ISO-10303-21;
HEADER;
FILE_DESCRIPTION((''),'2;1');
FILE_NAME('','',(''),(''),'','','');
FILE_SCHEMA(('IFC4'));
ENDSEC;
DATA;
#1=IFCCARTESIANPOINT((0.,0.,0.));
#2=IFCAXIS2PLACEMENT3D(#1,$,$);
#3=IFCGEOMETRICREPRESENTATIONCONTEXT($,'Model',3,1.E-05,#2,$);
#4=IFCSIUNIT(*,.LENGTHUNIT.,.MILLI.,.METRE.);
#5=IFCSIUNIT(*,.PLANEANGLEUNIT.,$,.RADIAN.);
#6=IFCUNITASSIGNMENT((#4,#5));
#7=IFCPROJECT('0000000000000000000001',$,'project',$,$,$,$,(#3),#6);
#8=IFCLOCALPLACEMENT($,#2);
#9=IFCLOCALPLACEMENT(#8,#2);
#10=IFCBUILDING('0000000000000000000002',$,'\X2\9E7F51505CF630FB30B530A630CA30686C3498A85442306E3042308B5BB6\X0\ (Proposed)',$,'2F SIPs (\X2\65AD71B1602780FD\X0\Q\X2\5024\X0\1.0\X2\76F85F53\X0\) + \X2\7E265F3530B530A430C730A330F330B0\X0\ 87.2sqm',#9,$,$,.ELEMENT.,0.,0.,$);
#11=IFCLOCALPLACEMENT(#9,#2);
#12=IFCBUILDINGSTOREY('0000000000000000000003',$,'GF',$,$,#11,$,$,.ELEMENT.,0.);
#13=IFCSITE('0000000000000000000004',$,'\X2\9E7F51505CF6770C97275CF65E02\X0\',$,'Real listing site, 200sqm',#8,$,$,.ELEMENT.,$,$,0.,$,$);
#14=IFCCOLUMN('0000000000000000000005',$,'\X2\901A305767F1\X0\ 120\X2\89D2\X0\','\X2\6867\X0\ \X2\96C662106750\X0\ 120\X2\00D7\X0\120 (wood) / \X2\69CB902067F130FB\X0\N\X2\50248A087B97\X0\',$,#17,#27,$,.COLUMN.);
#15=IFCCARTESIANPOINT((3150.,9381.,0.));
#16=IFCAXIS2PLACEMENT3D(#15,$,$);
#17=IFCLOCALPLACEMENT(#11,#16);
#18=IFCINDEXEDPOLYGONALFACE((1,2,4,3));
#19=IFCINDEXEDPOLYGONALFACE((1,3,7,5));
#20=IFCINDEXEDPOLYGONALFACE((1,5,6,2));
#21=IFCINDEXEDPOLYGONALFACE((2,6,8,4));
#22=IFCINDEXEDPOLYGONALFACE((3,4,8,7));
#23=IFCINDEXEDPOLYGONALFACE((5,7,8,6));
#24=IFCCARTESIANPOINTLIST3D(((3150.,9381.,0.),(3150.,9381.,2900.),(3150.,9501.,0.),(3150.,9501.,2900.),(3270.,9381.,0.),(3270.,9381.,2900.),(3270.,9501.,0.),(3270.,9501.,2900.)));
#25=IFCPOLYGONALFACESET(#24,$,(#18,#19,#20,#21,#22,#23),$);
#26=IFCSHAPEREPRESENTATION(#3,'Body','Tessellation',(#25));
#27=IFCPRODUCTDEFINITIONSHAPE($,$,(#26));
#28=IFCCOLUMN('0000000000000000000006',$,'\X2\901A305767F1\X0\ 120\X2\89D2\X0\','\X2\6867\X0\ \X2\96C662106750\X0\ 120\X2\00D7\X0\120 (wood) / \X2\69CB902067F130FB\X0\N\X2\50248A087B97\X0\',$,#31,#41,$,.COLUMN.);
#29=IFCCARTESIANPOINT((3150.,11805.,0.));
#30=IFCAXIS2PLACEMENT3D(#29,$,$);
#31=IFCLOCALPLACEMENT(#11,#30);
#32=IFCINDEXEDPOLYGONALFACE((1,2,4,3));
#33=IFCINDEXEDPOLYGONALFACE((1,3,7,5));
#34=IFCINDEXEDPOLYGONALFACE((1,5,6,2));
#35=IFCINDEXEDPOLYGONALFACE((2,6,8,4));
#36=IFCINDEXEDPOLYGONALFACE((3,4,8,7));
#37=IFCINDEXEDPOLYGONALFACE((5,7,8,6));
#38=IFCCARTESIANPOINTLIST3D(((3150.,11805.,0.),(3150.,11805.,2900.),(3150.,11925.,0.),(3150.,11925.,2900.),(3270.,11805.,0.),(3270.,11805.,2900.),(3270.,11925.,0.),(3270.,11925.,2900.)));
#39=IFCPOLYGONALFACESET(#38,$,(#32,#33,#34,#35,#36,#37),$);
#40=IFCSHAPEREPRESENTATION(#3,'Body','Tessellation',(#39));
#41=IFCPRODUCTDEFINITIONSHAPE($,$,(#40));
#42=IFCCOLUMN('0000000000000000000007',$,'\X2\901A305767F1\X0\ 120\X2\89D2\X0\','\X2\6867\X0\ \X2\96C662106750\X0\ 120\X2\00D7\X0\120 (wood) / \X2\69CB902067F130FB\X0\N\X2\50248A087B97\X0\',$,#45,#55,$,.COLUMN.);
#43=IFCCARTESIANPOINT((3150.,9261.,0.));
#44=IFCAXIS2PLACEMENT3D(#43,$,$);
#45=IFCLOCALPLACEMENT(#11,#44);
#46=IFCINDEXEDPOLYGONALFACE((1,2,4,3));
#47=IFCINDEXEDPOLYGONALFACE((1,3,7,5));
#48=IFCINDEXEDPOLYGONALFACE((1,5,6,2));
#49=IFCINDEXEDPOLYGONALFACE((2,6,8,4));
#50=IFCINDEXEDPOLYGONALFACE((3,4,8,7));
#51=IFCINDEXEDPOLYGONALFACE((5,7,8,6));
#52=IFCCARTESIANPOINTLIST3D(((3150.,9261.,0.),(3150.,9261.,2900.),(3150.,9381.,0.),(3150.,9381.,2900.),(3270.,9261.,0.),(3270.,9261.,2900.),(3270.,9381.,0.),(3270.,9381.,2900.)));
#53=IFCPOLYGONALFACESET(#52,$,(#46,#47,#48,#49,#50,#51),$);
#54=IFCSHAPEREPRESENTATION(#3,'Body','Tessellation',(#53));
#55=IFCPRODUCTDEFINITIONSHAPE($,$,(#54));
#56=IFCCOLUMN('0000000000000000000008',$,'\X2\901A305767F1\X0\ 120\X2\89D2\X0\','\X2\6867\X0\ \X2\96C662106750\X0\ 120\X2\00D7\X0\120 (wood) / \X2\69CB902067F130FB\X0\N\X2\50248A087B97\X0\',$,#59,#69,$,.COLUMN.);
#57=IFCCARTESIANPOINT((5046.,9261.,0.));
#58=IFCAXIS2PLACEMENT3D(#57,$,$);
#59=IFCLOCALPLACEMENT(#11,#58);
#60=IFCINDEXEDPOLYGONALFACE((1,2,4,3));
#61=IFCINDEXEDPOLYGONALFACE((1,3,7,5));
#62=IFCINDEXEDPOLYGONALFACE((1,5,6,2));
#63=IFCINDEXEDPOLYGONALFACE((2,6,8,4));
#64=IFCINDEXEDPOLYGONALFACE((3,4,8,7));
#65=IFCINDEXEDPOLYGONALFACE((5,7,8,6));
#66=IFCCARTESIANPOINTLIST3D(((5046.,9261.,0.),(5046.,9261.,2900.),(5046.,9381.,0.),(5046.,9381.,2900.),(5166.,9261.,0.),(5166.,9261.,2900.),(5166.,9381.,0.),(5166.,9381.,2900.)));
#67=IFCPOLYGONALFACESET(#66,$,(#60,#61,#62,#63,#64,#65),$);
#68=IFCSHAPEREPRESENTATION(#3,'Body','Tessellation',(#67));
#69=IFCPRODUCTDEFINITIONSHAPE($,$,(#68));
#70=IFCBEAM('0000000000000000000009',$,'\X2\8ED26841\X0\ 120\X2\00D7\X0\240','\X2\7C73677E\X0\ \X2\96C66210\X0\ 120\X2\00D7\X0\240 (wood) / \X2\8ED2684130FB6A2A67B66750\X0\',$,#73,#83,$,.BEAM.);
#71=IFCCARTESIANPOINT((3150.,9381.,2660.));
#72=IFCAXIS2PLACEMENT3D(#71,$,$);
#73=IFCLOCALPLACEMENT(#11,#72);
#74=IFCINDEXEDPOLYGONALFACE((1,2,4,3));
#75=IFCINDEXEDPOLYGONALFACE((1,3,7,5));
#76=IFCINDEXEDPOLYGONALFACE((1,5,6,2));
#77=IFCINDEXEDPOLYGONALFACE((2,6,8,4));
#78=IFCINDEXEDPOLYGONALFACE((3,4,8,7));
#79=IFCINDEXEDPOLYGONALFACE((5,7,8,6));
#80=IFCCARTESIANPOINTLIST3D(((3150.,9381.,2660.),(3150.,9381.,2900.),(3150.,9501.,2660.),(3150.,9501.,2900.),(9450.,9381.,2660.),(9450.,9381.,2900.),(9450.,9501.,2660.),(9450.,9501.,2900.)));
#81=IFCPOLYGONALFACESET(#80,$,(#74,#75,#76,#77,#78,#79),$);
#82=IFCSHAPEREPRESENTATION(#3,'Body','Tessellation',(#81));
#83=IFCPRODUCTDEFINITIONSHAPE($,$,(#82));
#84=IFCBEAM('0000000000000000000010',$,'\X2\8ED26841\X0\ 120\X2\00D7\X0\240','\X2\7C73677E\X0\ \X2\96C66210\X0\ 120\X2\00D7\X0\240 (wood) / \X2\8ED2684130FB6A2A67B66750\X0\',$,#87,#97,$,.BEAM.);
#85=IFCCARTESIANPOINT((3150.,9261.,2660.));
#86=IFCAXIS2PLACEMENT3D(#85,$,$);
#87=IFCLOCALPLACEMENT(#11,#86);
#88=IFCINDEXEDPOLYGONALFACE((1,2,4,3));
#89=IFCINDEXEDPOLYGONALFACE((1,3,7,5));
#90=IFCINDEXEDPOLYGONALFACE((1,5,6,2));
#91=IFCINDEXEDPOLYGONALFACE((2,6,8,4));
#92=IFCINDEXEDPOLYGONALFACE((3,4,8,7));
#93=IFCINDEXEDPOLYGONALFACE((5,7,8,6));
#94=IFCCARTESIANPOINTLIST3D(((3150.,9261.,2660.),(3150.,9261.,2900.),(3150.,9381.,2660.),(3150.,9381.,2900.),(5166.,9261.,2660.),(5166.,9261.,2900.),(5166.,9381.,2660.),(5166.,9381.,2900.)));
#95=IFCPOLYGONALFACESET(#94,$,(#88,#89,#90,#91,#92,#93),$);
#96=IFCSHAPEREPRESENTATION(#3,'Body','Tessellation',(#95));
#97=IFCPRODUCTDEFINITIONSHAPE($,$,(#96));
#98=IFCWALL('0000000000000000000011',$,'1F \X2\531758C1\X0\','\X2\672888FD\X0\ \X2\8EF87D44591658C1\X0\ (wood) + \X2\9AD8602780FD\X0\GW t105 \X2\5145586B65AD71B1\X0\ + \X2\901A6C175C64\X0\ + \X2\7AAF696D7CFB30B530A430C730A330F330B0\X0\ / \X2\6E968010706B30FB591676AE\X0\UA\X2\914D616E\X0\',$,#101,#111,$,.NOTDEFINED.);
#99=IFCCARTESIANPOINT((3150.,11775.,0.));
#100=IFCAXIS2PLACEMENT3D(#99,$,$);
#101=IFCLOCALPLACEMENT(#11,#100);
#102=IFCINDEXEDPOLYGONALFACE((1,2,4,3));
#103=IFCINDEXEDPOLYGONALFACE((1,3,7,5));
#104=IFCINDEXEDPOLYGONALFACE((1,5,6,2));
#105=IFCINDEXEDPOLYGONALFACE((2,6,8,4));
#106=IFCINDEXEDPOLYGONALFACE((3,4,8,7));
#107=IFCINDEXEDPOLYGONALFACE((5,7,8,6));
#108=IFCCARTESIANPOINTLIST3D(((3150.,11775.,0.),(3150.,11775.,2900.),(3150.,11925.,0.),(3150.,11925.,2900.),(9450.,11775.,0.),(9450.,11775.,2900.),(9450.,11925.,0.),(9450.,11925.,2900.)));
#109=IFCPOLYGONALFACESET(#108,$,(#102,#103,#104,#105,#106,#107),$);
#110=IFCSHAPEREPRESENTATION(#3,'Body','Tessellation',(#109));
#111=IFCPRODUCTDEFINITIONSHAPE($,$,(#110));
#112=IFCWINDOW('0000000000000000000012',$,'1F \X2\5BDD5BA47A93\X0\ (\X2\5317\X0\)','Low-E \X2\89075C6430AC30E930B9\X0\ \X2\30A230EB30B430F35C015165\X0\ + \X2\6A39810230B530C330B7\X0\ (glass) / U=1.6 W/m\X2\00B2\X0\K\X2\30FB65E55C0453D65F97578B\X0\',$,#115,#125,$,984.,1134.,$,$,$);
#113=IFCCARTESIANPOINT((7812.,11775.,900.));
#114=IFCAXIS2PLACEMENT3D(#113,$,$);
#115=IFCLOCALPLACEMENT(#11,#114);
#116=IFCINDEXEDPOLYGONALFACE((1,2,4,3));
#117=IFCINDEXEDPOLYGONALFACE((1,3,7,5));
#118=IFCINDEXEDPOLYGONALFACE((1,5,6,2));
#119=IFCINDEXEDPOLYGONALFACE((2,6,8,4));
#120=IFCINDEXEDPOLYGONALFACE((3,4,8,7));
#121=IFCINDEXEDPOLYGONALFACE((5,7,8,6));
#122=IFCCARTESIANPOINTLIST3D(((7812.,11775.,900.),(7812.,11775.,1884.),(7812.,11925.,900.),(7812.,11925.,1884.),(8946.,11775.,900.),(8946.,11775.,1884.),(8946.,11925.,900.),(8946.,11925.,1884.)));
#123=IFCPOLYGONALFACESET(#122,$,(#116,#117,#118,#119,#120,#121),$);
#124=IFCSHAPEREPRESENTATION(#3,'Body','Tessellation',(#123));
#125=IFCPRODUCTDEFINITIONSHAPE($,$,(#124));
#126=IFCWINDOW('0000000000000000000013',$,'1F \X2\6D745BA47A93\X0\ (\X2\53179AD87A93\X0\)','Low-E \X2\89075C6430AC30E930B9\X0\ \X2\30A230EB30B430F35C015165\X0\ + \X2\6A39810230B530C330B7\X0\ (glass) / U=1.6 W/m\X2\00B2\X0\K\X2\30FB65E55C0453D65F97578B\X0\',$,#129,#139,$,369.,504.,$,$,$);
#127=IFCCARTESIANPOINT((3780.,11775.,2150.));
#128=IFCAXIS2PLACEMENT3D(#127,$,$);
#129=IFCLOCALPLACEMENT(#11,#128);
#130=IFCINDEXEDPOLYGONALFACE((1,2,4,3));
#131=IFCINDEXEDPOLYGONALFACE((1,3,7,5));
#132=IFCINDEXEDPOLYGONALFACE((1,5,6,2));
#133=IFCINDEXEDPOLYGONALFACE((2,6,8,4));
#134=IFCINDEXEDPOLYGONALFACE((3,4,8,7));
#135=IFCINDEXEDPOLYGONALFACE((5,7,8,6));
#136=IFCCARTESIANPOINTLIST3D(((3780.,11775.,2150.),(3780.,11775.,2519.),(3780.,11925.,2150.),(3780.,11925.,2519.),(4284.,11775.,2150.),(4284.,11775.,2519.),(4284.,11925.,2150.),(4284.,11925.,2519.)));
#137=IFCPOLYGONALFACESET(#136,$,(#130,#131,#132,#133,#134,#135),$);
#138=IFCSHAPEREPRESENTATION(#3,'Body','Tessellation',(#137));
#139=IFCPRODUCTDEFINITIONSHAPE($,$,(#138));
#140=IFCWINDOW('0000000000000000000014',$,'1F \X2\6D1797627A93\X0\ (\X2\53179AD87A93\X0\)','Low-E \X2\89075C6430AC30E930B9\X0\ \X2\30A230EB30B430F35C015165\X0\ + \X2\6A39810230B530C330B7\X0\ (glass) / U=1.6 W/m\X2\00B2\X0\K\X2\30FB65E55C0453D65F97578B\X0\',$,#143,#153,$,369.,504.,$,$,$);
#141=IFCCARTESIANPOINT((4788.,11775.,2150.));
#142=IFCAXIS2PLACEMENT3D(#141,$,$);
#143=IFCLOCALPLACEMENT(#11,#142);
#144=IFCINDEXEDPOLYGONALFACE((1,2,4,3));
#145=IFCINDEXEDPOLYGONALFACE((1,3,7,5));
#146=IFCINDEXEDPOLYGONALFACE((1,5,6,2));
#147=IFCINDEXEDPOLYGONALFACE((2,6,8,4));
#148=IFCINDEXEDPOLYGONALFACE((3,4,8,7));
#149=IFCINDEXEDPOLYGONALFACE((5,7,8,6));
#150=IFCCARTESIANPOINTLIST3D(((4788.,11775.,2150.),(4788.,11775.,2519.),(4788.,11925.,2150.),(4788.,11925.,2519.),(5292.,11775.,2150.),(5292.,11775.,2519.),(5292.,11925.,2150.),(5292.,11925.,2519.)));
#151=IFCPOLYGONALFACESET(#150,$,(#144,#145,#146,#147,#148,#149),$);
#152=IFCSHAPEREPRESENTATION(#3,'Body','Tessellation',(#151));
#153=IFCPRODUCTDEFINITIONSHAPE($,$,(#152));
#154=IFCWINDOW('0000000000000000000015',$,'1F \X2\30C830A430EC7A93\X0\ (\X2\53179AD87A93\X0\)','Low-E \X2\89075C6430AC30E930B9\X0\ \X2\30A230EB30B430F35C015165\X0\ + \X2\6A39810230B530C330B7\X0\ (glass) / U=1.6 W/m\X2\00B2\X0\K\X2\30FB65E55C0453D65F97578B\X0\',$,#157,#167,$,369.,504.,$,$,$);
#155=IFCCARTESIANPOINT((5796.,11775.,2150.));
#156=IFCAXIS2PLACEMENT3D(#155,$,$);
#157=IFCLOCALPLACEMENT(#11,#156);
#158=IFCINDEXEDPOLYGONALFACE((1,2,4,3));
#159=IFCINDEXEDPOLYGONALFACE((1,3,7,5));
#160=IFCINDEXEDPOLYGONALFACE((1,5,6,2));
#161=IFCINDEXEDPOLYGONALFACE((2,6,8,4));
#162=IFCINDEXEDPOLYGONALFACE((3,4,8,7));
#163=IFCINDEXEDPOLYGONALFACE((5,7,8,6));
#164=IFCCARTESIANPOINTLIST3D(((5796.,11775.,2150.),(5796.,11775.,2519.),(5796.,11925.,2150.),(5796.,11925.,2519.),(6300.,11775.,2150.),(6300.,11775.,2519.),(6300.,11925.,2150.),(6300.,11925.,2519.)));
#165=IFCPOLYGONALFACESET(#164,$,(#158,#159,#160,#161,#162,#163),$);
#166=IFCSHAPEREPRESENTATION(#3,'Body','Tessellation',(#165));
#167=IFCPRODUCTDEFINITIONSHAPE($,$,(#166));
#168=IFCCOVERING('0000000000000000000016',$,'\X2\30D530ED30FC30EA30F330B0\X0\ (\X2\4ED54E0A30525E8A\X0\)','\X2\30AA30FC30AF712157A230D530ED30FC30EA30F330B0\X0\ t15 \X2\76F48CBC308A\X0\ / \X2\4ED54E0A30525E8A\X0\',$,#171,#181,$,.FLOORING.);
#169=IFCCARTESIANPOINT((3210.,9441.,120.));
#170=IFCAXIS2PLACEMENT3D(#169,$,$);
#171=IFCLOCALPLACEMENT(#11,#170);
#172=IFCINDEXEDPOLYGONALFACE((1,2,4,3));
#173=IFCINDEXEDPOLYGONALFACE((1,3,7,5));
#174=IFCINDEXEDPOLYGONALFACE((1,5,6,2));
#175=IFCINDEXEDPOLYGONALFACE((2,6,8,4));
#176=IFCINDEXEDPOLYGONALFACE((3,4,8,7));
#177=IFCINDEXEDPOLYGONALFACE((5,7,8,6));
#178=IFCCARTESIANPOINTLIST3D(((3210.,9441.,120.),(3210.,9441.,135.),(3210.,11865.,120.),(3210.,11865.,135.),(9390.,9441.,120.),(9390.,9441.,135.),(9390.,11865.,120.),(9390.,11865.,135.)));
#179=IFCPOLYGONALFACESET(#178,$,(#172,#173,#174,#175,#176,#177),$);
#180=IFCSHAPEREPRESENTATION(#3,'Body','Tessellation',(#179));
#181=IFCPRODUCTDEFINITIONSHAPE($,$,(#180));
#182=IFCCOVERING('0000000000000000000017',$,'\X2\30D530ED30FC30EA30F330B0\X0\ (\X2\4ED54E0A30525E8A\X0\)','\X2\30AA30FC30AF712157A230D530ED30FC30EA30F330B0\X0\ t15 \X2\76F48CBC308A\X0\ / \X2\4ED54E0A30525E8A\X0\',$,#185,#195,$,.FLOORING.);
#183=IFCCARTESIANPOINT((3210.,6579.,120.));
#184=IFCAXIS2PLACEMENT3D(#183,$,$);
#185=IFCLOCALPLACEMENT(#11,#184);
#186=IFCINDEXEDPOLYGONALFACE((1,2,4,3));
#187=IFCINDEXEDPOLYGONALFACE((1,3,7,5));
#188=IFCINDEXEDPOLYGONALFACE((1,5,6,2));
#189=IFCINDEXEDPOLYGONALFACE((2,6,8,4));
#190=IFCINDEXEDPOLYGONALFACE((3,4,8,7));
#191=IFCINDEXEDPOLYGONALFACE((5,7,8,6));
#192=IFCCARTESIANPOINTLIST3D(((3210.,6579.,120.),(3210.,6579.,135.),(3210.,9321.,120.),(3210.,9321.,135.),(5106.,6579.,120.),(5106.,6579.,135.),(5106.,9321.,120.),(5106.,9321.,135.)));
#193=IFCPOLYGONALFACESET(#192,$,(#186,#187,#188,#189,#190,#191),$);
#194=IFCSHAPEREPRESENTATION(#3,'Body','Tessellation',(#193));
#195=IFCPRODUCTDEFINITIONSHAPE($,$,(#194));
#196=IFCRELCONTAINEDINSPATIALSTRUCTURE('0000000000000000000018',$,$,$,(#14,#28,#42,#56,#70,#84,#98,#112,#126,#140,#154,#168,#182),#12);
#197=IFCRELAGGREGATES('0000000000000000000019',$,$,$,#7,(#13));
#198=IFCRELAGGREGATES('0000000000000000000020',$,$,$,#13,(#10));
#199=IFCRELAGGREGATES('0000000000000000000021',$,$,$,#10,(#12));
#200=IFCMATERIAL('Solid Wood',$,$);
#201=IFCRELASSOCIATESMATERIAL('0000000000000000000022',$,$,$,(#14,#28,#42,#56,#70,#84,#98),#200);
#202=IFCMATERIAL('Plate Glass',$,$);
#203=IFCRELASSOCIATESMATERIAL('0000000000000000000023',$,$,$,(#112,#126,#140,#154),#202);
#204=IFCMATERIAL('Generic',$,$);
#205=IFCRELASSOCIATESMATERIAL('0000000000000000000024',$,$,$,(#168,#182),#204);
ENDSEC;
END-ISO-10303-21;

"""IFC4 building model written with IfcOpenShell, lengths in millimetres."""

from ifc_helpers import new_model, si_unit, frame, frame_2d, origin, place, context, project, spatial, rectangle, extrude, material, element, fill, save


model = new_model("IFC4")

# Units and contexts
model_context = context("Model", 3, precision=1e-05, world=origin())
ifc_project = project(units=[si_unit("LENGTHUNIT", "METRE", prefix="MILLI"), si_unit("PLANEANGLEUNIT", "RADIAN")], contexts=[model_context])

# Site, building, storey
site_placement = place(None, origin())
site = spatial("IfcSite", under=ifc_project, at=site_placement, Name="鹿児島県霧島市", ObjectType="Real listing site, 200sqm", CompositionType="ELEMENT", RefElevation=0.0)
building_placement = place(site_placement, origin())
building = spatial("IfcBuilding", under=site, at=building_placement, Name="鹿児島・サウナと水風呂のある家 (Proposed)", ObjectType="2F SIPs (断熱性能Q値1.0相当) + 縦張サイディング 87.2sqm", CompositionType="ELEMENT", ElevationOfRefHeight=0.0, ElevationOfTerrain=0.0)
storey_placement = place(building_placement, origin())
storey = spatial("IfcBuildingStorey", under=building, at=storey_placement, Name="GF", CompositionType="ELEMENT", Elevation=0.0)

# Columns
ifc_material_1 = material(Name="Solid Wood")
column_1_placement = place(storey_placement, frame((3150.0, 9381.0, 0.0)))
element("IfcColumn", 1, at=column_1_placement, inside=storey, material=ifc_material_1, Name="通し柱 120角", Description="桧 集成材 120×120 (wood) / 構造柱・N値計算", PredefinedType="COLUMN", context=model_context, shape_type="SweptSolid", body=[
    extrude(rectangle(XDim=120.0, YDim=120.0, at=frame_2d((60.0, 60.0))), frame((3150.0, 9381.0, 0.0)), (0.0, 0.0, 1.0), 2900.0),
])
column_2_placement = place(storey_placement, frame((3150.0, 11805.0, 0.0)))
element("IfcColumn", 2, at=column_2_placement, inside=storey, material=ifc_material_1, Name="通し柱 120角", Description="桧 集成材 120×120 (wood) / 構造柱・N値計算", PredefinedType="COLUMN", context=model_context, shape_type="SweptSolid", body=[
    extrude(rectangle(XDim=120.0, YDim=120.0, at=frame_2d((60.0, 60.0))), frame((3150.0, 11805.0, 0.0)), (0.0, 0.0, 1.0), 2900.0),
])
column_3_placement = place(storey_placement, frame((3150.0, 9261.0, 0.0)))
element("IfcColumn", 3, at=column_3_placement, inside=storey, material=ifc_material_1, Name="通し柱 120角", Description="桧 集成材 120×120 (wood) / 構造柱・N値計算", PredefinedType="COLUMN", context=model_context, shape_type="SweptSolid", body=[
    extrude(rectangle(XDim=120.0, YDim=120.0, at=frame_2d((60.0, 60.0))), frame((3150.0, 9261.0, 0.0)), (0.0, 0.0, 1.0), 2900.0),
])
column_4_placement = place(storey_placement, frame((5046.0, 9261.0, 0.0)))
element("IfcColumn", 4, at=column_4_placement, inside=storey, material=ifc_material_1, Name="通し柱 120角", Description="桧 集成材 120×120 (wood) / 構造柱・N値計算", PredefinedType="COLUMN", context=model_context, shape_type="SweptSolid", body=[
    extrude(rectangle(XDim=120.0, YDim=120.0, at=frame_2d((60.0, 60.0))), frame((5046.0, 9261.0, 0.0)), (0.0, 0.0, 1.0), 2900.0),
])

# Beams
beam_1_placement = place(storey_placement, frame((3150.0, 9381.0, 2660.0)))
element("IfcBeam", 5, at=beam_1_placement, inside=storey, material=ifc_material_1, Name="軒桁 120×240", Description="米松 集成 120×240 (wood) / 軒桁・横架材", PredefinedType="BEAM", context=model_context, shape_type="SweptSolid", body=[
    extrude(rectangle(XDim=6300.0, YDim=120.0, at=frame_2d((3150.0, 60.0))), frame((3150.0, 9381.0, 2660.0)), (0.0, 0.0, 1.0), 240.0),
])
beam_2_placement = place(storey_placement, frame((3150.0, 9261.0, 2660.0)))
element("IfcBeam", 6, at=beam_2_placement, inside=storey, material=ifc_material_1, Name="軒桁 120×240", Description="米松 集成 120×240 (wood) / 軒桁・横架材", PredefinedType="BEAM", context=model_context, shape_type="SweptSolid", body=[
    extrude(rectangle(XDim=2016.0, YDim=120.0, at=frame_2d((1008.0, 60.0))), frame((3150.0, 9261.0, 2660.0)), (0.0, 0.0, 1.0), 240.0),
])

# Wall, openings, windows
wall_1_placement = place(storey_placement, frame((3150.0, 11775.0, 0.0)))
wall_1 = element("IfcWall", 7, at=wall_1_placement, inside=storey, material=ifc_material_1, Name="1F 北壁", Description="木製 軸組外壁 (wood) + 高性能GW t105 充填断熱 + 通気層 + 窯業系サイディング / 準耐火・外皮UA配慮", PredefinedType="NOTDEFINED", context=model_context, shape_type="SweptSolid", body=[
    extrude(rectangle(XDim=6300.0, YDim=150.0, at=frame_2d((3150.0, 75.0))), frame((3150.0, 11775.0, 0.0)), (0.0, 0.0, 1.0), 2900.0),
])
opening_1_placement = place(storey_placement, frame((7812.0, 11775.0, 900.0)))
opening_1 = element("IfcOpeningElement", 8, at=opening_1_placement, cuts=wall_1, PredefinedType="NOTDEFINED", context=model_context, shape_type="SweptSolid", body=[
    extrude(rectangle(XDim=1134.0, YDim=150.0, at=frame_2d((567.0, 75.0))), frame((7812.0, 11775.0, 900.0)), (0.0, 0.0, 1.0), 984.0),
])
opening_2_placement = place(storey_placement, frame((3780.0, 11775.0, 2150.0)))
opening_2 = element("IfcOpeningElement", 9, at=opening_2_placement, cuts=wall_1, PredefinedType="NOTDEFINED", context=model_context, shape_type="SweptSolid", body=[
    extrude(rectangle(XDim=504.0, YDim=150.0, at=frame_2d((252.0, 75.0))), frame((3780.0, 11775.0, 2150.0)), (0.0, 0.0, 1.0), 369.0),
])
opening_3_placement = place(storey_placement, frame((4788.0, 11775.0, 2150.0)))
opening_3 = element("IfcOpeningElement", 10, at=opening_3_placement, cuts=wall_1, PredefinedType="NOTDEFINED", context=model_context, shape_type="SweptSolid", body=[
    extrude(rectangle(XDim=504.0, YDim=150.0, at=frame_2d((252.0, 75.0))), frame((4788.0, 11775.0, 2150.0)), (0.0, 0.0, 1.0), 369.0),
])
opening_4_placement = place(storey_placement, frame((5796.0, 11775.0, 2150.0)))
opening_4 = element("IfcOpeningElement", 11, at=opening_4_placement, cuts=wall_1, PredefinedType="NOTDEFINED", context=model_context, shape_type="SweptSolid", body=[
    extrude(rectangle(XDim=504.0, YDim=150.0, at=frame_2d((252.0, 75.0))), frame((5796.0, 11775.0, 2150.0)), (0.0, 0.0, 1.0), 369.0),
])
ifc_material_2 = material(Name="Plate Glass")
window_1_placement = place(storey_placement, frame((7812.0, 11775.0, 900.0)))
window_1 = element("IfcWindow", 12, at=window_1_placement, inside=storey, material=ifc_material_2, Name="1F 寝室窓 (北)", Description="Low-E 複層ガラス アルゴン封入 + 樹脂サッシ (glass) / U=1.6 W/m²K・日射取得型", OverallHeight=984.0, OverallWidth=1134.0, context=model_context, shape_type="SweptSolid", body=[
    extrude(rectangle(XDim=1134.0, YDim=150.0, at=frame_2d((567.0, 75.0))), frame((7812.0, 11775.0, 900.0)), (0.0, 0.0, 1.0), 984.0),
])
fill(opening_1, window_1)
window_2_placement = place(storey_placement, frame((3780.0, 11775.0, 2150.0)))
window_2 = element("IfcWindow", 13, at=window_2_placement, inside=storey, material=ifc_material_2, Name="1F 浴室窓 (北高窓)", Description="Low-E 複層ガラス アルゴン封入 + 樹脂サッシ (glass) / U=1.6 W/m²K・日射取得型", OverallHeight=369.0, OverallWidth=504.0, context=model_context, shape_type="SweptSolid", body=[
    extrude(rectangle(XDim=504.0, YDim=150.0, at=frame_2d((252.0, 75.0))), frame((3780.0, 11775.0, 2150.0)), (0.0, 0.0, 1.0), 369.0),
])
fill(opening_2, window_2)
window_3_placement = place(storey_placement, frame((4788.0, 11775.0, 2150.0)))
window_3 = element("IfcWindow", 14, at=window_3_placement, inside=storey, material=ifc_material_2, Name="1F 洗面窓 (北高窓)", Description="Low-E 複層ガラス アルゴン封入 + 樹脂サッシ (glass) / U=1.6 W/m²K・日射取得型", OverallHeight=369.0, OverallWidth=504.0, context=model_context, shape_type="SweptSolid", body=[
    extrude(rectangle(XDim=504.0, YDim=150.0, at=frame_2d((252.0, 75.0))), frame((4788.0, 11775.0, 2150.0)), (0.0, 0.0, 1.0), 369.0),
])
fill(opening_3, window_3)
window_4_placement = place(storey_placement, frame((5796.0, 11775.0, 2150.0)))
window_4 = element("IfcWindow", 15, at=window_4_placement, inside=storey, material=ifc_material_2, Name="1F トイレ窓 (北高窓)", Description="Low-E 複層ガラス アルゴン封入 + 樹脂サッシ (glass) / U=1.6 W/m²K・日射取得型", OverallHeight=369.0, OverallWidth=504.0, context=model_context, shape_type="SweptSolid", body=[
    extrude(rectangle(XDim=504.0, YDim=150.0, at=frame_2d((252.0, 75.0))), frame((5796.0, 11775.0, 2150.0)), (0.0, 0.0, 1.0), 369.0),
])
fill(opening_4, window_4)

# Coverings
ifc_material_3 = material(Name="Generic")
covering_1_placement = place(storey_placement, frame((3210.0, 9441.0, 120.0)))
element("IfcCovering", 16, at=covering_1_placement, inside=storey, material=ifc_material_3, Name="フローリング (仕上げ床)", Description="オーク無垢フローリング t15 直貼り / 仕上げ床", PredefinedType="FLOORING", context=model_context, shape_type="SweptSolid", body=[
    extrude(rectangle(XDim=6180.0, YDim=2424.0, at=frame_2d((3090.0, 1212.0))), frame((3210.0, 9441.0, 120.0)), (0.0, 0.0, 1.0), 15.0),
])
covering_2_placement = place(storey_placement, frame((3210.0, 6579.0, 120.0)))
element("IfcCovering", 17, at=covering_2_placement, inside=storey, material=ifc_material_3, Name="フローリング (仕上げ床)", Description="オーク無垢フローリング t15 直貼り / 仕上げ床", PredefinedType="FLOORING", context=model_context, shape_type="SweptSolid", body=[
    extrude(rectangle(XDim=1896.0, YDim=2742.0, at=frame_2d((948.0, 1371.0))), frame((3210.0, 6579.0, 120.0)), (0.0, 0.0, 1.0), 15.0),
])

save(model, "model.ifc")
